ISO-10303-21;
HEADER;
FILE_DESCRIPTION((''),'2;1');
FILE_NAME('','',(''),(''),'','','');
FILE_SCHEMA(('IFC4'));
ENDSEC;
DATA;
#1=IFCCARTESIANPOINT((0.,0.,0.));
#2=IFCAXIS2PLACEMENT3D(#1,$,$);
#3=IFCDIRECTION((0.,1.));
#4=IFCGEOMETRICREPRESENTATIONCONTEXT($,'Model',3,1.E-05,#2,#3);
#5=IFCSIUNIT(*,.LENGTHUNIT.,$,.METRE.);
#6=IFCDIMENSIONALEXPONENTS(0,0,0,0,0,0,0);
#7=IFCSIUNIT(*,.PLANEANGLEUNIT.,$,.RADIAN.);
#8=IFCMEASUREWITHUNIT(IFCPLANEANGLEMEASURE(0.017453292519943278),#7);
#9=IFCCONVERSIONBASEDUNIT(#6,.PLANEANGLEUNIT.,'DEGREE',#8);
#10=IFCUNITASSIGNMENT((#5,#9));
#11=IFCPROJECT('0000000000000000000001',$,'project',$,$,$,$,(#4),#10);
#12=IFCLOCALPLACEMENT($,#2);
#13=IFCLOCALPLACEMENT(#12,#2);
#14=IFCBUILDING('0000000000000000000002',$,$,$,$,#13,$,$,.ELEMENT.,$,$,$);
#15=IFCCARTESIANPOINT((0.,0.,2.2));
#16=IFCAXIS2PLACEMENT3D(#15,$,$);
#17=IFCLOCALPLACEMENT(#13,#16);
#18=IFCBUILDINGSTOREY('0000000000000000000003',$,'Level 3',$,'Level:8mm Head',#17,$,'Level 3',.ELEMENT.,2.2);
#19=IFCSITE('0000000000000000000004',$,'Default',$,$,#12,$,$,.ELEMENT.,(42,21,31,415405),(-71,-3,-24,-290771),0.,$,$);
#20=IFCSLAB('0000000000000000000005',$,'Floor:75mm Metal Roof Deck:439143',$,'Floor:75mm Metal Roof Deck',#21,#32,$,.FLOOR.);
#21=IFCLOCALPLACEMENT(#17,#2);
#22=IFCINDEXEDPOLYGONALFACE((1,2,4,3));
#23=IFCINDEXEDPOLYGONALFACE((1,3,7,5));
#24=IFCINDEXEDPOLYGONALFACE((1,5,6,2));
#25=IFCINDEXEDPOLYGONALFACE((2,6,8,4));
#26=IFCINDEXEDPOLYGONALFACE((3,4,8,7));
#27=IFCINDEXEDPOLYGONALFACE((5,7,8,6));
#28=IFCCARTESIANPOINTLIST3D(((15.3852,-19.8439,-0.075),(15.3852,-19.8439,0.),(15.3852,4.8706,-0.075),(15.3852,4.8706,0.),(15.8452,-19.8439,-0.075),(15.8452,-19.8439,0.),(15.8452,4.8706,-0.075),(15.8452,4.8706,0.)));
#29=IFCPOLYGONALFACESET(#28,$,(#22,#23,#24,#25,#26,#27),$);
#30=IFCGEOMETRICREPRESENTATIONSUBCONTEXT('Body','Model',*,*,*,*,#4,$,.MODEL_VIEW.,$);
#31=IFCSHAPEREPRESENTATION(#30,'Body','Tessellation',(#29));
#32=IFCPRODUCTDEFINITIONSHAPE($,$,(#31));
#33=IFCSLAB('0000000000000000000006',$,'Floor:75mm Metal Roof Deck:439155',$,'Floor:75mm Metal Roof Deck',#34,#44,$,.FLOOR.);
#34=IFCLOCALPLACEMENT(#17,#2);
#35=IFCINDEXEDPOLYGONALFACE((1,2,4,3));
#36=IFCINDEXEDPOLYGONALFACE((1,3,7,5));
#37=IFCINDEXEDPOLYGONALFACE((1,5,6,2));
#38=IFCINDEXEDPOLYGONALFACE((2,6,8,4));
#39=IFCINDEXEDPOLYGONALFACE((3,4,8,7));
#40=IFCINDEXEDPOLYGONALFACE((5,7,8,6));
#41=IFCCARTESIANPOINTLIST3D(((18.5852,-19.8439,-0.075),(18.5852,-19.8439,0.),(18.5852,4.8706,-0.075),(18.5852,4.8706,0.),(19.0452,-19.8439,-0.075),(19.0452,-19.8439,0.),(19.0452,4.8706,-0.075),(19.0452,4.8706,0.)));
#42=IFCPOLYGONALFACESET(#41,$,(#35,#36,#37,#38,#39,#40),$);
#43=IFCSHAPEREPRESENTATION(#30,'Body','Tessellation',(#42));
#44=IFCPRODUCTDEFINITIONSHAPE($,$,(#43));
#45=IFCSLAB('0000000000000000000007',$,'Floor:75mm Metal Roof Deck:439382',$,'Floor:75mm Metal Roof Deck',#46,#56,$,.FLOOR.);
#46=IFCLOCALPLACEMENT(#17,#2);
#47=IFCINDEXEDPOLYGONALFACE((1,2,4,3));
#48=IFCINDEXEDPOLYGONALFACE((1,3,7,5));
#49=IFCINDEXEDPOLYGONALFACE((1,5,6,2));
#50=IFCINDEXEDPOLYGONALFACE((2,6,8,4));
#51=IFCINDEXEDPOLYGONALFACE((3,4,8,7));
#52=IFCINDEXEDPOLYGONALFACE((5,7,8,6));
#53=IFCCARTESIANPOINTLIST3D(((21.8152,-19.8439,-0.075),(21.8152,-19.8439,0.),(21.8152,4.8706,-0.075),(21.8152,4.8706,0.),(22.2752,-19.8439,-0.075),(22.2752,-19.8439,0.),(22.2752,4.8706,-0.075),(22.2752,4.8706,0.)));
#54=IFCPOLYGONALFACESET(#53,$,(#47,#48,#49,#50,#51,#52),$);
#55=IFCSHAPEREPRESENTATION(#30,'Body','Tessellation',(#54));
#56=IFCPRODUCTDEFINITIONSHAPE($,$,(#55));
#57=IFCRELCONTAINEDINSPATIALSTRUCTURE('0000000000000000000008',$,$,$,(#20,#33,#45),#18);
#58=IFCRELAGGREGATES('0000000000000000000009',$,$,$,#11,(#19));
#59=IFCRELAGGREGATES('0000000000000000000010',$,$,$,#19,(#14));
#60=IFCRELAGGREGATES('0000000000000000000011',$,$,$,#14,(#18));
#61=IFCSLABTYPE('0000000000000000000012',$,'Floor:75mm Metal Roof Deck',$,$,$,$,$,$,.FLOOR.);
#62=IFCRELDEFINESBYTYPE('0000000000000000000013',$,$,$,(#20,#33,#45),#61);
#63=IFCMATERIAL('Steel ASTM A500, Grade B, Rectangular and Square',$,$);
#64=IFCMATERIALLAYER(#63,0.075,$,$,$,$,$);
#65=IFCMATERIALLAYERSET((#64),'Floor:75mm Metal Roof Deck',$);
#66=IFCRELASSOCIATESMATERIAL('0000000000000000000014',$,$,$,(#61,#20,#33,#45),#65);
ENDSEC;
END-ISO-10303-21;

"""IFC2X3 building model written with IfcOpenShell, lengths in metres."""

from ifc_helpers import new_model, entity, si_unit, converted_unit, direction, frame, frame_2d, origin, origin_2d_with_axis, place, context, subcontext, project, spatial, rectangle, extrude, material, layer, layer_set, layer_usage, type_object, element, save


model = new_model("IFC2X3")

# Units and contexts
model_context = context("Model", 3, precision=1e-05, world=origin(), true_north=direction((0.0, 1.0)))
body_context = subcontext(model_context, "Body", "Model", "MODEL_VIEW")
ifc_project = project(units=[si_unit("LENGTHUNIT", "METRE"), converted_unit("PLANEANGLEUNIT", "DEGREE", entity("IfcPlaneAngleMeasure", 0.017453292519943278), si_unit("PLANEANGLEUNIT", "RADIAN"), dimensions=[0, 0, 0, 0, 0, 0, 0])], contexts=[model_context])

# Site, building, storey
site_placement = place(None, origin())
site = spatial("IfcSite", under=ifc_project, at=site_placement, Name="Default", CompositionType="ELEMENT", RefLatitude=(42, 21, 31, 415405), RefLongitude=(-71, -3, -24, -290771), RefElevation=0.0)
building_placement = place(site_placement, origin())
building = spatial("IfcBuilding", under=site, at=building_placement, CompositionType="ELEMENT")
storey_placement = place(building_placement, frame((0.0, 0.0, 2.2)))
storey = spatial("IfcBuildingStorey", under=building, at=storey_placement, Name="Level 3", ObjectType="Level:8mm Head", LongName="Level 3", CompositionType="ELEMENT", Elevation=2.2)

# Slabs
ifc_material = material(Name="Steel ASTM A500, Grade B, Rectangular and Square")
ifc_layer = layer(ifc_material, 0.075)
ifc_layer_set = layer_set([ifc_layer], Name="Floor:75mm Metal Roof Deck")
slab_type = type_object("IfcSlabType", Name="Floor:75mm Metal Roof Deck", PredefinedType="FLOOR", material=ifc_layer_set)
ifc_layer_usage_1 = layer_usage(ifc_layer_set, "AXIS3", "POSITIVE", 0.0)
slab_1_placement = place(storey_placement, origin())
element("IfcSlab", 1, at=slab_1_placement, inside=storey, type_object=slab_type, material=ifc_layer_usage_1, Name="Floor:75mm Metal Roof Deck:439143", ObjectType="Floor:75mm Metal Roof Deck", PredefinedType="FLOOR", context=body_context, shape_type="SweptSolid", body=[
    extrude(rectangle(XDim=24.7144, YDim=0.46, at=frame_2d((0.0, 0.0), x_axis=(1.0, 0.0))), frame((15.6152, -7.4867, 0.0), z_axis=(0.0, 0.0, -1.0), x_axis=(0.0, 1.0, 0.0)), (0.0, 0.0, 1.0), 0.075),
])
ifc_layer_usage_2 = layer_usage(ifc_layer_set, "AXIS3", "POSITIVE", 0.0)
slab_2_placement = place(storey_placement, origin())
element("IfcSlab", 2, at=slab_2_placement, inside=storey, type_object=slab_type, material=ifc_layer_usage_2, Name="Floor:75mm Metal Roof Deck:439155", ObjectType="Floor:75mm Metal Roof Deck", PredefinedType="FLOOR", context=body_context, shape_type="SweptSolid", body=[
    extrude(rectangle(XDim=24.7144, YDim=0.46, at=frame_2d((0.0, 0.0), x_axis=(1.0, 0.0))), frame((18.8152, -7.4867, 0.0), z_axis=(0.0, 0.0, -1.0), x_axis=(0.0, 1.0, 0.0)), (0.0, 0.0, 1.0), 0.075),
])
ifc_layer_usage_3 = layer_usage(ifc_layer_set, "AXIS3", "POSITIVE", 0.0)
slab_3_placement = place(storey_placement, origin())
element("IfcSlab", 3, at=slab_3_placement, inside=storey, type_object=slab_type, material=ifc_layer_usage_3, Name="Floor:75mm Metal Roof Deck:439382", ObjectType="Floor:75mm Metal Roof Deck", PredefinedType="FLOOR", context=body_context, shape_type="SweptSolid", body=[
    extrude(rectangle(XDim=24.7144, YDim=0.46, at=origin_2d_with_axis()), frame((22.0452, -7.4867, 0.0), z_axis=(0.0, 0.0, -1.0), x_axis=(0.0, 1.0, 0.0)), (0.0, 0.0, 1.0), 0.075),
])

save(model, "model.ifc")
